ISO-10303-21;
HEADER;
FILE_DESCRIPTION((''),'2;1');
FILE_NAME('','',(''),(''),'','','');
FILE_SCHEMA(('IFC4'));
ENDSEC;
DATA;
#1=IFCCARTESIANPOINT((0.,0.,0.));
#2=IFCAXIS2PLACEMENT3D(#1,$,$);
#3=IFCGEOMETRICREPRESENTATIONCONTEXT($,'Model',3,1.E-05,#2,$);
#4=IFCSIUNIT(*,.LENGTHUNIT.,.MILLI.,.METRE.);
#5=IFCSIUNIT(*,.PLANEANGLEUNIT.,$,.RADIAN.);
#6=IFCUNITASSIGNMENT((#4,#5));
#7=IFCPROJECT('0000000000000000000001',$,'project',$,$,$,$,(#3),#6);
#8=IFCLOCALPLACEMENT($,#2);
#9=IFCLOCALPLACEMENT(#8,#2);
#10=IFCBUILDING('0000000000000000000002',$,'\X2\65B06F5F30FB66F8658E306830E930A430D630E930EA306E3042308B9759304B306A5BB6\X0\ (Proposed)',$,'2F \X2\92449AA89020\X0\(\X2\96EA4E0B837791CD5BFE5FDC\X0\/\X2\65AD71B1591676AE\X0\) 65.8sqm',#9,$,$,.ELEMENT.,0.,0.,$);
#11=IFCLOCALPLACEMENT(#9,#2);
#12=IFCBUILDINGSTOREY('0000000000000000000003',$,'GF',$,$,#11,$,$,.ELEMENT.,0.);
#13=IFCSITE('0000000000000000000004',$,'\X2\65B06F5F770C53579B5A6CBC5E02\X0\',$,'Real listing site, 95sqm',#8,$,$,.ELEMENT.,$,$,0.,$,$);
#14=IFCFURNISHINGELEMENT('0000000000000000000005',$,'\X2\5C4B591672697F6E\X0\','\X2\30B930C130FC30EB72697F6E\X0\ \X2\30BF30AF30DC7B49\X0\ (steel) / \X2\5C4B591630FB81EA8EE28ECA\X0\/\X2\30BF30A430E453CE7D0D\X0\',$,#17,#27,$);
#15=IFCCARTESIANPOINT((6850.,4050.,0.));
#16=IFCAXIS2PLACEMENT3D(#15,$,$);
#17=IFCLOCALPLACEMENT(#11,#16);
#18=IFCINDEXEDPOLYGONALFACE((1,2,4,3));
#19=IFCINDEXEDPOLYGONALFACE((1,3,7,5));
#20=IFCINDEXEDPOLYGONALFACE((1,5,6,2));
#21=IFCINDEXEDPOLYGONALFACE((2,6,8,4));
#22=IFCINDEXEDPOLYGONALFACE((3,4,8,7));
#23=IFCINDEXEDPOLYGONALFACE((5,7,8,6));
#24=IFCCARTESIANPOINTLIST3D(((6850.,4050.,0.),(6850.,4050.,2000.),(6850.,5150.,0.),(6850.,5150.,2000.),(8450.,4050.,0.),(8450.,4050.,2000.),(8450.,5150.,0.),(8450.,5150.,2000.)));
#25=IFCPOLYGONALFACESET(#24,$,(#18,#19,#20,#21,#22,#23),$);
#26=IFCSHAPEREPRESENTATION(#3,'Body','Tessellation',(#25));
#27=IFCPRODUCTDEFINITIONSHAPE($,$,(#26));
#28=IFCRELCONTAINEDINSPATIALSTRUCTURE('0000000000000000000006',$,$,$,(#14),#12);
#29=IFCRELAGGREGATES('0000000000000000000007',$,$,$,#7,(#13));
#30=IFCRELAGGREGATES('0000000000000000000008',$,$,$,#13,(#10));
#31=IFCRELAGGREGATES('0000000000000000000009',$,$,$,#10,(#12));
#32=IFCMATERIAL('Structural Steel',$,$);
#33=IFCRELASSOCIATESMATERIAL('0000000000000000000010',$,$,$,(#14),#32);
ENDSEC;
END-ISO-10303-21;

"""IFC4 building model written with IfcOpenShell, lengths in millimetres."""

from ifc_helpers import new_model, si_unit, frame, frame_2d, origin, place, context, project, spatial, rectangle, extrude, material, element, save


model = new_model("IFC4")

# Units and contexts
model_context = context("Model", 3, precision=1e-05, world=origin())
ifc_project = project(units=[si_unit("LENGTHUNIT", "METRE", prefix="MILLI"), si_unit("PLANEANGLEUNIT", "RADIAN")], contexts=[model_context])

# Site, building, storey
site_placement = place(None, origin())
site = spatial("IfcSite", under=ifc_project, at=site_placement, Name="新潟県南魚沼市", ObjectType="Real listing site, 95sqm", CompositionType="ELEMENT", RefElevation=0.0)
building_placement = place(site_placement, origin())
building = spatial("IfcBuilding", under=site, at=building_placement, Name="新潟・書斎とライブラリのある静かな家 (Proposed)", ObjectType="2F 鉄骨造(雪下荷重対応/断熱外皮) 65.8sqm", CompositionType="ELEMENT", ElevationOfRefHeight=0.0, ElevationOfTerrain=0.0)
storey_placement = place(building_placement, origin())
storey = spatial("IfcBuildingStorey", under=building, at=storey_placement, Name="GF", CompositionType="ELEMENT", Elevation=0.0)

# Shared definitions
ifc_material_1 = material(Name="Structural Steel")

# Furnishing element
furnishing_1_placement = place(storey_placement, frame((6850.0, 4050.0, 0.0)))
element("IfcFurnishingElement", 1, at=furnishing_1_placement, inside=storey, material=ifc_material_1, Name="屋外物置", Description="スチール物置 タクボ等 (steel) / 屋外・自転車/タイヤ収納", context=model_context, shape_type="SweptSolid", body=[
    extrude(rectangle(XDim=1600.0, YDim=1100.0, at=frame_2d((800.0, 550.0))), frame((6850.0, 4050.0, 0.0)), (0.0, 0.0, 1.0), 2000.0),
])

save(model, "model.ifc")
